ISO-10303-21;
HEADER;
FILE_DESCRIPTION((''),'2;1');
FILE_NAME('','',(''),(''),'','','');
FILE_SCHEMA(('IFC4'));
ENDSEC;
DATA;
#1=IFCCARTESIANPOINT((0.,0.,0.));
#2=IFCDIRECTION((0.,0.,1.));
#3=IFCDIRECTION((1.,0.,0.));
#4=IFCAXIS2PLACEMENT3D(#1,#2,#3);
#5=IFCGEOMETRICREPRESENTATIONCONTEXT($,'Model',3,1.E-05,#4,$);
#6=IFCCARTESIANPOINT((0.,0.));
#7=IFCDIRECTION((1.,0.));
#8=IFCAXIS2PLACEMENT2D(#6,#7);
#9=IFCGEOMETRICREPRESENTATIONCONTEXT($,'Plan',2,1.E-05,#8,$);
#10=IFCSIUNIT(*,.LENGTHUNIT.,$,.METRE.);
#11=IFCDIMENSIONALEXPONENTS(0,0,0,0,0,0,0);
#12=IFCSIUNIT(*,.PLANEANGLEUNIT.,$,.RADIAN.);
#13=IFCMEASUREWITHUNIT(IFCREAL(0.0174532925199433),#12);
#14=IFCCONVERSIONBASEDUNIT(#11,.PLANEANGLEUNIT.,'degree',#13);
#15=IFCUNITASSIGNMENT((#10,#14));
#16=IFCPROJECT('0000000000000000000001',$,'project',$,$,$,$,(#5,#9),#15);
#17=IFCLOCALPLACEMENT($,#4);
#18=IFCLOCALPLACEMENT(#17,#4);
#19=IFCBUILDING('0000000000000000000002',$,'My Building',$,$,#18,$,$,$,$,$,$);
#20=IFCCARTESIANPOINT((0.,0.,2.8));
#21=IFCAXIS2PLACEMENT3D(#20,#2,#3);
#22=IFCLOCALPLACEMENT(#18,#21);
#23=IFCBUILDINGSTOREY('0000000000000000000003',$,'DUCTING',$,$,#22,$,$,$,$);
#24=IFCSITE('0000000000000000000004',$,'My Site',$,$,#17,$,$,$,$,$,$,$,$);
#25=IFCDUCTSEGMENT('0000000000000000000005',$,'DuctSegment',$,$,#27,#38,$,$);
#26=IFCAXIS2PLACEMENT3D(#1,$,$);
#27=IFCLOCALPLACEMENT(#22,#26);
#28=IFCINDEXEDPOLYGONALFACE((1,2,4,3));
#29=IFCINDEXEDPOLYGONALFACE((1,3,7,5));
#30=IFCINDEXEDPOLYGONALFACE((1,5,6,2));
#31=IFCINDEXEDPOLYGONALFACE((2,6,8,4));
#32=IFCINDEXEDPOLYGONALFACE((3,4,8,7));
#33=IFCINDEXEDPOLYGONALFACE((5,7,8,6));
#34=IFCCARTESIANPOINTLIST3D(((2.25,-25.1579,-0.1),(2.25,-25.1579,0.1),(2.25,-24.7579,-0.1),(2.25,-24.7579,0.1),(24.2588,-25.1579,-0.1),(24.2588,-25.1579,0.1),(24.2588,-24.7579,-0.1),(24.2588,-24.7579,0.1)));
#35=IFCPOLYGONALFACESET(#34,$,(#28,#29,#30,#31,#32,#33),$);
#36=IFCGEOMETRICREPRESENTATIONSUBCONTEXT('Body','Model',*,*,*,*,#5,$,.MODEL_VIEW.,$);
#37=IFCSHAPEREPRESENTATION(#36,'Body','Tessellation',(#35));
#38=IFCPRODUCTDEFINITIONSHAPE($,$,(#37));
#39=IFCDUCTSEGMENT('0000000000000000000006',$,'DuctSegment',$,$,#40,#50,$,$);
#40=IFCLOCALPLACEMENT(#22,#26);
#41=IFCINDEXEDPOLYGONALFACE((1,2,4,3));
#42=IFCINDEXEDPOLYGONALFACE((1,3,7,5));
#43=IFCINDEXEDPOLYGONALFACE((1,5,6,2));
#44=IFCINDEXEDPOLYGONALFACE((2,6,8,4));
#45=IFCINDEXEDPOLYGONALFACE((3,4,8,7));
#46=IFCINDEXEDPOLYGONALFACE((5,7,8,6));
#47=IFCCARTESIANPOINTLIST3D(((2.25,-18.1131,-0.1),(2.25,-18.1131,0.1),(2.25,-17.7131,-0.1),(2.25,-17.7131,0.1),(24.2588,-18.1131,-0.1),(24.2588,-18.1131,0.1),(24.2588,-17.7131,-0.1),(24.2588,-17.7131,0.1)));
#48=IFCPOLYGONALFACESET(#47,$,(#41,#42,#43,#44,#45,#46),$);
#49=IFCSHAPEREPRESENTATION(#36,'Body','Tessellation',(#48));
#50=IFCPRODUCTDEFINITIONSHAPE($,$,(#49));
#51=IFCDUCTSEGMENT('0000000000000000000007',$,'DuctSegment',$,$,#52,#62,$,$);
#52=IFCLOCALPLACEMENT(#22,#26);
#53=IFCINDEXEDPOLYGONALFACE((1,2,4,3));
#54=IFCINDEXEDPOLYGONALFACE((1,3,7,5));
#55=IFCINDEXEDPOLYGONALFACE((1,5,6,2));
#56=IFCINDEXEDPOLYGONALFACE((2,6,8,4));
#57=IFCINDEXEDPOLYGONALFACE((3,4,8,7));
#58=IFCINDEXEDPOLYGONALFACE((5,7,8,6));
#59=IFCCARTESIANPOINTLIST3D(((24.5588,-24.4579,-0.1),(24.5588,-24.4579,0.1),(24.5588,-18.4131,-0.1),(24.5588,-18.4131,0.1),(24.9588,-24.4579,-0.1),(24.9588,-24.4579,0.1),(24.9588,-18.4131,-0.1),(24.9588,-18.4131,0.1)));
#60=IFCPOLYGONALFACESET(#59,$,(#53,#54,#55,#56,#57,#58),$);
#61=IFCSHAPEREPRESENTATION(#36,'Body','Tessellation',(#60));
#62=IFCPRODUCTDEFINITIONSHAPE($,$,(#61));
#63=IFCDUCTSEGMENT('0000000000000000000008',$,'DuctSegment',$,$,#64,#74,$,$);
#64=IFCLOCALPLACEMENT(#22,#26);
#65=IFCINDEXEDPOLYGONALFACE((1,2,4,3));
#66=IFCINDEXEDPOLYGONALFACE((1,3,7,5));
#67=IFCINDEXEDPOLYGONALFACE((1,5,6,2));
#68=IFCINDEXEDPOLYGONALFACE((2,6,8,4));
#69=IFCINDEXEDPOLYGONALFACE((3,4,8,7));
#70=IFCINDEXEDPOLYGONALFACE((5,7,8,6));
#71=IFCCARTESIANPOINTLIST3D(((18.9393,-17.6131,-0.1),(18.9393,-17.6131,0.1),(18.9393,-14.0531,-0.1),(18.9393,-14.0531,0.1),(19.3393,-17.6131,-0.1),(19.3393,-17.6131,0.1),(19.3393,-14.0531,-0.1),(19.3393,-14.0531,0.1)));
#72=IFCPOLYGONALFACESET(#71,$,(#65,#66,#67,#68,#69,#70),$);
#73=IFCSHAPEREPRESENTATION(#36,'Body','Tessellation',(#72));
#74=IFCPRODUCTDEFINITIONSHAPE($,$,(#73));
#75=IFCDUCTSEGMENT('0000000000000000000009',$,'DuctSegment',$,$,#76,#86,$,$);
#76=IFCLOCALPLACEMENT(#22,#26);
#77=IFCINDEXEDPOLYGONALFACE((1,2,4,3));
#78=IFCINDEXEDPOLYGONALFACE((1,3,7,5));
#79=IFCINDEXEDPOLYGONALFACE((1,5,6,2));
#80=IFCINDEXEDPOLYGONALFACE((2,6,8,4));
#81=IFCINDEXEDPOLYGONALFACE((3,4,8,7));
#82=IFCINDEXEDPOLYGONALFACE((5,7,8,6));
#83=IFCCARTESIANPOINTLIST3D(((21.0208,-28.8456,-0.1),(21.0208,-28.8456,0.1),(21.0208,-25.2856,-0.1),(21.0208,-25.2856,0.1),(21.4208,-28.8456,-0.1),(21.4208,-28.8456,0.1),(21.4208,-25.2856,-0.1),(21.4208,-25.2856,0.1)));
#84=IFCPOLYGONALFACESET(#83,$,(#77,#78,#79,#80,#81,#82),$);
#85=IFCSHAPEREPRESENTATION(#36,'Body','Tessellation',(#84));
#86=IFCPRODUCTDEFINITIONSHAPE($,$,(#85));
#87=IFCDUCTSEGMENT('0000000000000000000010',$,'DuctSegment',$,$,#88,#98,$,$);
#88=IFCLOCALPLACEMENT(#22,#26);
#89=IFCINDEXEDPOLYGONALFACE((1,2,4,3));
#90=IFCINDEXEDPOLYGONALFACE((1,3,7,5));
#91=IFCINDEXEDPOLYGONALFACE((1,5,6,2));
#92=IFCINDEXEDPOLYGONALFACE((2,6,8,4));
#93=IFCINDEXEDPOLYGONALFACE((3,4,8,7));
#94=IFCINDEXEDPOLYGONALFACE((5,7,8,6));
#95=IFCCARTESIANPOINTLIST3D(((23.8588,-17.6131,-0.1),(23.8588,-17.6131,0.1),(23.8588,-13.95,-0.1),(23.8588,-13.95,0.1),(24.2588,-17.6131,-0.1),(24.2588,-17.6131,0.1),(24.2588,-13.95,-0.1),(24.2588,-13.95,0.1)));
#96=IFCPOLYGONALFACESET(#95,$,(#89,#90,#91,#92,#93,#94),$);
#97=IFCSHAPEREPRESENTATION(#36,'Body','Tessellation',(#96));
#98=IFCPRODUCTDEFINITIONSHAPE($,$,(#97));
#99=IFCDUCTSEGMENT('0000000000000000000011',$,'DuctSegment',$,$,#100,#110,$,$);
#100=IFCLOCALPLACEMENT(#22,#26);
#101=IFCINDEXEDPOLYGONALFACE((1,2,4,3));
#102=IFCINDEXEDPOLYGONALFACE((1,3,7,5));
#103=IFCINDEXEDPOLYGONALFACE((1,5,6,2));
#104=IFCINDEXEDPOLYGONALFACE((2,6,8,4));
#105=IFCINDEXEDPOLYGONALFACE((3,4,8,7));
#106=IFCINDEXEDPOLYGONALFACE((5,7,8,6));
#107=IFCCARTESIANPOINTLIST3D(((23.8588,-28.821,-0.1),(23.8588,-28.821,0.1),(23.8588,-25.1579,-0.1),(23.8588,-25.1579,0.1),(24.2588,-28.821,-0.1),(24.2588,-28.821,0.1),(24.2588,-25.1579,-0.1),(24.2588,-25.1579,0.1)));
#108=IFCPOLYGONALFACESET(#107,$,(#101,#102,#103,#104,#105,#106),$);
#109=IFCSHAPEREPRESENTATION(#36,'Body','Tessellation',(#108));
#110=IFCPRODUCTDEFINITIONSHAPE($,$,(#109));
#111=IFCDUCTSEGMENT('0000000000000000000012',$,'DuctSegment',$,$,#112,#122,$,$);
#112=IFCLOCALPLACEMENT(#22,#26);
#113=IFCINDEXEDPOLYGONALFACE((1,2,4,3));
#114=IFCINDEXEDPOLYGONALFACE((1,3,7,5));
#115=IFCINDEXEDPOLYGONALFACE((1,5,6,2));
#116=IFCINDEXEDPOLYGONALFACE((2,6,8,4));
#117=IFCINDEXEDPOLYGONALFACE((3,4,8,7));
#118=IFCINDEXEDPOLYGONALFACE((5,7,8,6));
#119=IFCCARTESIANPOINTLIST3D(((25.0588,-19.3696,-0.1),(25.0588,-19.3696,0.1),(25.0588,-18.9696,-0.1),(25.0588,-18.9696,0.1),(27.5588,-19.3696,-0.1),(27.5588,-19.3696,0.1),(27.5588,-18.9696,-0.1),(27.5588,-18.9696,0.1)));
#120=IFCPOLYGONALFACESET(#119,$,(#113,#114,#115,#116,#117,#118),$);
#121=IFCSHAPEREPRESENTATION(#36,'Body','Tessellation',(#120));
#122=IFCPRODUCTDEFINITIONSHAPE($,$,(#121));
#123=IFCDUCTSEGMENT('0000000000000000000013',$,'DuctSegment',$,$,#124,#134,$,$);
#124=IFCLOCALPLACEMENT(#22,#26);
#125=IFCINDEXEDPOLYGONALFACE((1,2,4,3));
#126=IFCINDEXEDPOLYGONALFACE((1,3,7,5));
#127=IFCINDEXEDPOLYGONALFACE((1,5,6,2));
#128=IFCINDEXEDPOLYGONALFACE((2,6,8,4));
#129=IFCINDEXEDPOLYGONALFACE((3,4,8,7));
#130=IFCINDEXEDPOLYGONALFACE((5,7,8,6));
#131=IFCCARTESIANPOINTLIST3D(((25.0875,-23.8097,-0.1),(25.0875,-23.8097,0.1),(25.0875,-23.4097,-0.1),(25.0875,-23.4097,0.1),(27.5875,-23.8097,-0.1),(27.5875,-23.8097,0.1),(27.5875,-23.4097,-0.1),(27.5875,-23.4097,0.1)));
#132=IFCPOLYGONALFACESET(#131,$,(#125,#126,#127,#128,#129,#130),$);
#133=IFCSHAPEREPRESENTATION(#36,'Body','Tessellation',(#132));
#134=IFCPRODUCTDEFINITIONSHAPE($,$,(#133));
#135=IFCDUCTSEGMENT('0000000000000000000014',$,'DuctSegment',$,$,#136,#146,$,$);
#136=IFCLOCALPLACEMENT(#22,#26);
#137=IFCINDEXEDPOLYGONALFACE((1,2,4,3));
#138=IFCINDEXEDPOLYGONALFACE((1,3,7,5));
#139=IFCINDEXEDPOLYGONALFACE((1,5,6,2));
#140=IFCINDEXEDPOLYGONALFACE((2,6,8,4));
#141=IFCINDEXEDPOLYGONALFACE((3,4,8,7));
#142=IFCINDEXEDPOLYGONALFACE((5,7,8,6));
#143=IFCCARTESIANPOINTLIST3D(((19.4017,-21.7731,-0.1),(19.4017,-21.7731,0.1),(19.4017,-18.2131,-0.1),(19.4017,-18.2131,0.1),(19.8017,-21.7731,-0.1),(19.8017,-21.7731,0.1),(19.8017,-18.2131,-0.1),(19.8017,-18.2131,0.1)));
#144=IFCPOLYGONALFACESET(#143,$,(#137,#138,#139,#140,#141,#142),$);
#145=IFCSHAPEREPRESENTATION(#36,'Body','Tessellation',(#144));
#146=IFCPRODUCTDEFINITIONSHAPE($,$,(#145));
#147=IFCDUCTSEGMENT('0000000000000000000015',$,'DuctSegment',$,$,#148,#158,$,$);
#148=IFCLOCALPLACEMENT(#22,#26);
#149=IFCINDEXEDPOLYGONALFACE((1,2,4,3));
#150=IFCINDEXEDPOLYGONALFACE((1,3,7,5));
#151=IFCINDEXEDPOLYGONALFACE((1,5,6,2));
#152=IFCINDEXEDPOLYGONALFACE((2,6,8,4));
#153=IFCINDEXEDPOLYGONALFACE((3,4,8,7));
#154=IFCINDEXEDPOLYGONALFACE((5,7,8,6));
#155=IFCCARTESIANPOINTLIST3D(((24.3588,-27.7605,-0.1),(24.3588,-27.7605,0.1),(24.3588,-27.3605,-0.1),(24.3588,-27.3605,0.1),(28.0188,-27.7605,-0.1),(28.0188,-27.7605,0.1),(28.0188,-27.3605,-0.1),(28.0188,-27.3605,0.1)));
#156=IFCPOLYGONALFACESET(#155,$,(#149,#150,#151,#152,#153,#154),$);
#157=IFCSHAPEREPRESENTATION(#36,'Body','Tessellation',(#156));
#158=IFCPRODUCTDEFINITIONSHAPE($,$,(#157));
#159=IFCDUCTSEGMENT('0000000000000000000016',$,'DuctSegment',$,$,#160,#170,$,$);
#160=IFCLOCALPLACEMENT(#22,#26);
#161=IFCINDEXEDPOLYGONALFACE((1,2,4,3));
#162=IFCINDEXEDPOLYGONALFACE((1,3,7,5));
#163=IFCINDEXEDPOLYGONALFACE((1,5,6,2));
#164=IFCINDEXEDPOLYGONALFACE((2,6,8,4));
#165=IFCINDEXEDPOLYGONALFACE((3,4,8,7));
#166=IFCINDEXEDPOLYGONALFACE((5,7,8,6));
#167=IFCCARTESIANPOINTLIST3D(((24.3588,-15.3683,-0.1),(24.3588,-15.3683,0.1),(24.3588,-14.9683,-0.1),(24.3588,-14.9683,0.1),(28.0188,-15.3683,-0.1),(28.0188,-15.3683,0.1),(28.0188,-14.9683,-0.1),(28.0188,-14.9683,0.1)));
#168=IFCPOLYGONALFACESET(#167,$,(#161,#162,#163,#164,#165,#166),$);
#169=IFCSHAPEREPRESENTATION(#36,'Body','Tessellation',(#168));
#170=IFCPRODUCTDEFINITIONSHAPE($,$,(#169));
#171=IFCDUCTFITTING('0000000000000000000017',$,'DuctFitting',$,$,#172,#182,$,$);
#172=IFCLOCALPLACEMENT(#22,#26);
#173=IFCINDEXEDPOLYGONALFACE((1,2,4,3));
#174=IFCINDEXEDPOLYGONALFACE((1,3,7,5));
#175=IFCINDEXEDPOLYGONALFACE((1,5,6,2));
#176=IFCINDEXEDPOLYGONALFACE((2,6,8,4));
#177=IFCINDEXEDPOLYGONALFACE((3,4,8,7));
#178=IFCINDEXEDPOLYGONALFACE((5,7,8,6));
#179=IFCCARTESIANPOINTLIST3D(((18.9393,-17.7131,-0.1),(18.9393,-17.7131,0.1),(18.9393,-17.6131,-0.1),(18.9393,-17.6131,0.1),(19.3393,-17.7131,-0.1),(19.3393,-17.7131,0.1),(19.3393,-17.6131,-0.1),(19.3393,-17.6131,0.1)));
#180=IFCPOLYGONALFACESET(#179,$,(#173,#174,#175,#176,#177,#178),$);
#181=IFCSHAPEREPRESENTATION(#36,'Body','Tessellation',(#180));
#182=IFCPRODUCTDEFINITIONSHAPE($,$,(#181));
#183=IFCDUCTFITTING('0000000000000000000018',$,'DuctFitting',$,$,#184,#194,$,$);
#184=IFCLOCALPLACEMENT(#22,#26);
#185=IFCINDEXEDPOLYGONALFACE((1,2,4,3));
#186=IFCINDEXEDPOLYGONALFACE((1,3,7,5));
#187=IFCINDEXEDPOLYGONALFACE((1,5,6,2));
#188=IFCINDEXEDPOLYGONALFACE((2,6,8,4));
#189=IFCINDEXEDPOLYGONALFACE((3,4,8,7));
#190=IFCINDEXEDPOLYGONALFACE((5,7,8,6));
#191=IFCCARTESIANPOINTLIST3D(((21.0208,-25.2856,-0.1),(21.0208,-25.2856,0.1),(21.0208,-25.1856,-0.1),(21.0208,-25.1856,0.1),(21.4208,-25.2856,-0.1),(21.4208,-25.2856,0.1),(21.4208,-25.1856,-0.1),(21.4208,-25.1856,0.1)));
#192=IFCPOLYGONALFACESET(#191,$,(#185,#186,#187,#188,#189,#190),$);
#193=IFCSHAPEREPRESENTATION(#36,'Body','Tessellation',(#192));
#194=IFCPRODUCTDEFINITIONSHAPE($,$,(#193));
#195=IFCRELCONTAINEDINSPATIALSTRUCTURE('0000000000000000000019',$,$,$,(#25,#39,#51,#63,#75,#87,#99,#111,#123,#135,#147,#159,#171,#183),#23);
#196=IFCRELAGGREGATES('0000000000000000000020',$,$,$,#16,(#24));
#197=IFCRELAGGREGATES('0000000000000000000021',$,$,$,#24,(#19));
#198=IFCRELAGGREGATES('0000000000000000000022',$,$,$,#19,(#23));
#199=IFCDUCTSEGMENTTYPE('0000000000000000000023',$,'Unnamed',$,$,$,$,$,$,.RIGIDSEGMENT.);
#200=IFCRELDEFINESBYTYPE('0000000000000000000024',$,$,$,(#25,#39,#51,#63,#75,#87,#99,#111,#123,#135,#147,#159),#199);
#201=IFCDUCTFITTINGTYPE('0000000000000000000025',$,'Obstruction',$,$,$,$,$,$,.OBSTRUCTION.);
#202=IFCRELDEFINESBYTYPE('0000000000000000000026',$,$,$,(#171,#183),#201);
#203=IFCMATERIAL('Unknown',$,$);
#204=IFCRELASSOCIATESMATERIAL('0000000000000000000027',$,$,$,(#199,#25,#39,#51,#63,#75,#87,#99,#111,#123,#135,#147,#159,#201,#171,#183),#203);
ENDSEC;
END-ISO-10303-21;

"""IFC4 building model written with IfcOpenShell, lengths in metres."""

from ifc_helpers import new_model, entity, si_unit, converted_unit, frame, origin_with_axes, origin_2d_with_axis, place, context, subcontext, project, spatial, rectangle, extrude, material, material_profile, profile_set, profile_usage, type_object, element, save


model = new_model("IFC4")

# Units and contexts
model_context = context("Model", 3, precision=1e-05, world=origin_with_axes())
plan_context = context("Plan", 2, precision=1e-05, world=origin_2d_with_axis())
body_context = subcontext(model_context, "Body", "Model", "MODEL_VIEW")
ifc_project = project(units=[si_unit("LENGTHUNIT", "METRE"), converted_unit("PLANEANGLEUNIT", "degree", entity("IfcReal", 0.0174532925199433), si_unit("PLANEANGLEUNIT", "RADIAN"), dimensions=[0, 0, 0, 0, 0, 0, 0])], contexts=[model_context, plan_context])

# Site, building, storey
site_placement = place(None, origin_with_axes())
site = spatial("IfcSite", under=ifc_project, at=site_placement, Name="My Site")
building_placement = place(site_placement, origin_with_axes())
building = spatial("IfcBuilding", under=site, at=building_placement, Name="My Building")
storey_placement = place(building_placement, frame((0.0, 0.0, 2.8), z_axis=(0.0, 0.0, 1.0), x_axis=(1.0, 0.0, 0.0)))
storey = spatial("IfcBuildingStorey", under=building, at=storey_placement, Name="DUCTING")

# Duct segments
ifc_material = material(Name="Unknown")
ifc_material_profile_1 = material_profile(ifc_material, rectangle(XDim=0.4, YDim=0.2))
ifc_profile_set_1 = profile_set([ifc_material_profile_1])
ifc_profile_usage_1 = profile_usage(ifc_profile_set_1, cardinal=5)
duct_segment_type = type_object("IfcDuctSegmentType", Name="Unnamed", PredefinedType="RIGIDSEGMENT", material=ifc_profile_set_1)
duct_segment_1_placement = place(storey_placement, frame((24.2588, -24.9579, 0.0), z_axis=(-1.0, 0.0, 0.0), x_axis=(0.0, -1.0, 0.0)))
element("IfcDuctSegment", 1, at=duct_segment_1_placement, inside=storey, type_object=duct_segment_type, material=ifc_profile_usage_1, Name="DuctSegment", context=body_context, shape_type="SweptSolid", body=[
    extrude(rectangle(XDim=0.4, YDim=0.2), origin_with_axes(), (0.0, 0.0, 1.0), 22.0088),
])
ifc_profile_usage_2 = profile_usage(ifc_profile_set_1, cardinal=5)
duct_segment_2_placement = place(storey_placement, frame((24.2588, -17.9131, 0.0), z_axis=(-1.0, 0.0, 0.0), x_axis=(0.0, -1.0, 0.0)))
element("IfcDuctSegment", 2, at=duct_segment_2_placement, inside=storey, type_object=duct_segment_type, material=ifc_profile_usage_2, Name="DuctSegment", context=body_context, shape_type="SweptSolid", body=[
    extrude(rectangle(XDim=0.4, YDim=0.2), origin_with_axes(), (0.0, 0.0, 1.0), 22.0088),
])
ifc_profile_usage_3 = profile_usage(ifc_profile_set_1, cardinal=5)
duct_segment_3_placement = place(storey_placement, frame((24.7588, -18.4131, 0.0), z_axis=(0.0, -1.0, 0.0), x_axis=(1.0, 0.0, 0.0)))
element("IfcDuctSegment", 3, at=duct_segment_3_placement, inside=storey, type_object=duct_segment_type, material=ifc_profile_usage_3, Name="DuctSegment", context=body_context, shape_type="SweptSolid", body=[
    extrude(rectangle(XDim=0.4, YDim=0.2), origin_with_axes(), (0.0, 0.0, 1.0), 6.0448),
])
ifc_profile_usage_4 = profile_usage(ifc_profile_set_1, cardinal=5)
duct_segment_4_placement = place(storey_placement, frame((19.1393, -14.0531, 0.0), z_axis=(0.0, -1.0, 0.0), x_axis=(1.0, 0.0, 0.0)))
element("IfcDuctSegment", 4, at=duct_segment_4_placement, inside=storey, type_object=duct_segment_type, material=ifc_profile_usage_4, Name="DuctSegment", context=body_context, shape_type="SweptSolid", body=[
    extrude(rectangle(XDim=0.4, YDim=0.2), origin_with_axes(), (0.0, 0.0, 1.0), 3.56),
])
ifc_profile_usage_5 = profile_usage(ifc_profile_set_1, cardinal=5)
duct_segment_5_placement = place(storey_placement, frame((21.2208, -28.8456, 0.0), z_axis=(0.0, 1.0, 0.0), x_axis=(-1.0, 0.0, 0.0)))
element("IfcDuctSegment", 5, at=duct_segment_5_placement, inside=storey, type_object=duct_segment_type, material=ifc_profile_usage_5, Name="DuctSegment", context=body_context, shape_type="SweptSolid", body=[
    extrude(rectangle(XDim=0.4, YDim=0.2), origin_with_axes(), (0.0, 0.0, 1.0), 3.56),
])
ifc_profile_usage_6 = profile_usage(ifc_profile_set_1, cardinal=5)
duct_segment_6_placement = place(storey_placement, frame((24.0588, -17.6131, 0.0), z_axis=(0.0, 1.0, 0.0), x_axis=(-1.0, 0.0, 0.0)))
element("IfcDuctSegment", 6, at=duct_segment_6_placement, inside=storey, type_object=duct_segment_type, material=ifc_profile_usage_6, Name="DuctSegment", context=body_context, shape_type="SweptSolid", body=[
    extrude(rectangle(XDim=0.4, YDim=0.2), origin_with_axes(), (0.0, 0.0, 1.0), 3.6631),
])
ifc_profile_usage_7 = profile_usage(ifc_profile_set_1, cardinal=5)
duct_segment_7_placement = place(storey_placement, frame((24.0588, -25.1579, 0.0), z_axis=(0.0, -1.0, 0.0), x_axis=(-1.0, 0.0, 0.0)))
element("IfcDuctSegment", 7, at=duct_segment_7_placement, inside=storey, type_object=duct_segment_type, material=ifc_profile_usage_7, Name="DuctSegment", context=body_context, shape_type="SweptSolid", body=[
    extrude(rectangle(XDim=0.4, YDim=0.2), origin_with_axes(), (0.0, 0.0, 1.0), 3.6631),
])
ifc_profile_usage_8 = profile_usage(ifc_profile_set_1, cardinal=5)
duct_segment_8_placement = place(storey_placement, frame((27.5588, -19.1696, 0.0), z_axis=(-1.0, 0.0, 0.0), x_axis=(0.0, -1.0, 0.0)))
element("IfcDuctSegment", 8, at=duct_segment_8_placement, inside=storey, type_object=duct_segment_type, material=ifc_profile_usage_8, Name="DuctSegment", context=body_context, shape_type="SweptSolid", body=[
    extrude(rectangle(XDim=0.4, YDim=0.2), origin_with_axes(), (0.0, 0.0, 1.0), 2.5),
])
ifc_profile_usage_9 = profile_usage(ifc_profile_set_1, cardinal=5)
duct_segment_9_placement = place(storey_placement, frame((27.5875, -23.6097, 0.0), z_axis=(-1.0, 0.0, 0.0), x_axis=(0.0, -1.0, 0.0)))
element("IfcDuctSegment", 9, at=duct_segment_9_placement, inside=storey, type_object=duct_segment_type, material=ifc_profile_usage_9, Name="DuctSegment", context=body_context, shape_type="SweptSolid", body=[
    extrude(rectangle(XDim=0.4, YDim=0.2), origin_with_axes(), (0.0, 0.0, 1.0), 2.5),
])
ifc_profile_usage_10 = profile_usage(ifc_profile_set_1, cardinal=5)
duct_segment_10_placement = place(storey_placement, frame((19.6017, -21.7731, 0.0), z_axis=(0.0, 1.0, 0.0), x_axis=(-1.0, 0.0, 0.0)))
element("IfcDuctSegment", 10, at=duct_segment_10_placement, inside=storey, type_object=duct_segment_type, material=ifc_profile_usage_10, Name="DuctSegment", context=body_context, shape_type="SweptSolid", body=[
    extrude(rectangle(XDim=0.4, YDim=0.2), origin_with_axes(), (0.0, 0.0, 1.0), 3.56),
])
ifc_profile_usage_11 = profile_usage(ifc_profile_set_1, cardinal=5)
duct_segment_11_placement = place(storey_placement, frame((28.0188, -27.5605, 0.0), z_axis=(-1.0, 0.0, 0.0), x_axis=(0.0, -1.0, 0.0)))
element("IfcDuctSegment", 11, at=duct_segment_11_placement, inside=storey, type_object=duct_segment_type, material=ifc_profile_usage_11, Name="DuctSegment", context=body_context, shape_type="SweptSolid", body=[
    extrude(rectangle(XDim=0.4, YDim=0.2), origin_with_axes(), (0.0, 0.0, 1.0), 3.66),
])
ifc_profile_usage_12 = profile_usage(ifc_profile_set_1, cardinal=5)
duct_segment_12_placement = place(storey_placement, frame((28.0188, -15.1683, 0.0), z_axis=(-1.0, 0.0, 0.0), x_axis=(0.0, -1.0, 0.0)))
element("IfcDuctSegment", 12, at=duct_segment_12_placement, inside=storey, type_object=duct_segment_type, material=ifc_profile_usage_12, Name="DuctSegment", context=body_context, shape_type="SweptSolid", body=[
    extrude(rectangle(XDim=0.4, YDim=0.2), origin_with_axes(), (0.0, 0.0, 1.0), 3.66),
])

# Duct fittings
ifc_material_profile_2 = material_profile(ifc_material, rectangle(XDim=0.4, YDim=0.2))
ifc_profile_set_2 = profile_set([ifc_material_profile_2])
ifc_profile_usage_13 = profile_usage(ifc_profile_set_2, cardinal=5)
duct_fitting_type = type_object("IfcDuctFittingType", Name="Obstruction", PredefinedType="OBSTRUCTION", material=ifc_profile_set_2)
duct_fitting_1_placement = place(storey_placement, frame((19.1393, -17.6131, 0.0), z_axis=(0.0, -1.0, 0.0), x_axis=(1.0, 0.0, 0.0)))
element("IfcDuctFitting", 13, at=duct_fitting_1_placement, inside=storey, type_object=duct_fitting_type, material=ifc_profile_usage_13, Name="DuctFitting", context=body_context, shape_type="SweptSolid", body=[
    extrude(rectangle(XDim=0.4, YDim=0.2), origin_with_axes(), (0.0, 0.0, 1.0), 0.1),
])
ifc_profile_usage_14 = profile_usage(ifc_profile_set_2, cardinal=5)
duct_fitting_2_placement = place(storey_placement, frame((21.2208, -25.2856, 0.0), z_axis=(0.0, 1.0, 0.0), x_axis=(-1.0, 0.0, 0.0)))
element("IfcDuctFitting", 14, at=duct_fitting_2_placement, inside=storey, type_object=duct_fitting_type, material=ifc_profile_usage_14, Name="DuctFitting", context=body_context, shape_type="SweptSolid", body=[
    extrude(rectangle(XDim=0.4, YDim=0.2), origin_with_axes(), (0.0, 0.0, 1.0), 0.1),
])

save(model, "model.ifc")
